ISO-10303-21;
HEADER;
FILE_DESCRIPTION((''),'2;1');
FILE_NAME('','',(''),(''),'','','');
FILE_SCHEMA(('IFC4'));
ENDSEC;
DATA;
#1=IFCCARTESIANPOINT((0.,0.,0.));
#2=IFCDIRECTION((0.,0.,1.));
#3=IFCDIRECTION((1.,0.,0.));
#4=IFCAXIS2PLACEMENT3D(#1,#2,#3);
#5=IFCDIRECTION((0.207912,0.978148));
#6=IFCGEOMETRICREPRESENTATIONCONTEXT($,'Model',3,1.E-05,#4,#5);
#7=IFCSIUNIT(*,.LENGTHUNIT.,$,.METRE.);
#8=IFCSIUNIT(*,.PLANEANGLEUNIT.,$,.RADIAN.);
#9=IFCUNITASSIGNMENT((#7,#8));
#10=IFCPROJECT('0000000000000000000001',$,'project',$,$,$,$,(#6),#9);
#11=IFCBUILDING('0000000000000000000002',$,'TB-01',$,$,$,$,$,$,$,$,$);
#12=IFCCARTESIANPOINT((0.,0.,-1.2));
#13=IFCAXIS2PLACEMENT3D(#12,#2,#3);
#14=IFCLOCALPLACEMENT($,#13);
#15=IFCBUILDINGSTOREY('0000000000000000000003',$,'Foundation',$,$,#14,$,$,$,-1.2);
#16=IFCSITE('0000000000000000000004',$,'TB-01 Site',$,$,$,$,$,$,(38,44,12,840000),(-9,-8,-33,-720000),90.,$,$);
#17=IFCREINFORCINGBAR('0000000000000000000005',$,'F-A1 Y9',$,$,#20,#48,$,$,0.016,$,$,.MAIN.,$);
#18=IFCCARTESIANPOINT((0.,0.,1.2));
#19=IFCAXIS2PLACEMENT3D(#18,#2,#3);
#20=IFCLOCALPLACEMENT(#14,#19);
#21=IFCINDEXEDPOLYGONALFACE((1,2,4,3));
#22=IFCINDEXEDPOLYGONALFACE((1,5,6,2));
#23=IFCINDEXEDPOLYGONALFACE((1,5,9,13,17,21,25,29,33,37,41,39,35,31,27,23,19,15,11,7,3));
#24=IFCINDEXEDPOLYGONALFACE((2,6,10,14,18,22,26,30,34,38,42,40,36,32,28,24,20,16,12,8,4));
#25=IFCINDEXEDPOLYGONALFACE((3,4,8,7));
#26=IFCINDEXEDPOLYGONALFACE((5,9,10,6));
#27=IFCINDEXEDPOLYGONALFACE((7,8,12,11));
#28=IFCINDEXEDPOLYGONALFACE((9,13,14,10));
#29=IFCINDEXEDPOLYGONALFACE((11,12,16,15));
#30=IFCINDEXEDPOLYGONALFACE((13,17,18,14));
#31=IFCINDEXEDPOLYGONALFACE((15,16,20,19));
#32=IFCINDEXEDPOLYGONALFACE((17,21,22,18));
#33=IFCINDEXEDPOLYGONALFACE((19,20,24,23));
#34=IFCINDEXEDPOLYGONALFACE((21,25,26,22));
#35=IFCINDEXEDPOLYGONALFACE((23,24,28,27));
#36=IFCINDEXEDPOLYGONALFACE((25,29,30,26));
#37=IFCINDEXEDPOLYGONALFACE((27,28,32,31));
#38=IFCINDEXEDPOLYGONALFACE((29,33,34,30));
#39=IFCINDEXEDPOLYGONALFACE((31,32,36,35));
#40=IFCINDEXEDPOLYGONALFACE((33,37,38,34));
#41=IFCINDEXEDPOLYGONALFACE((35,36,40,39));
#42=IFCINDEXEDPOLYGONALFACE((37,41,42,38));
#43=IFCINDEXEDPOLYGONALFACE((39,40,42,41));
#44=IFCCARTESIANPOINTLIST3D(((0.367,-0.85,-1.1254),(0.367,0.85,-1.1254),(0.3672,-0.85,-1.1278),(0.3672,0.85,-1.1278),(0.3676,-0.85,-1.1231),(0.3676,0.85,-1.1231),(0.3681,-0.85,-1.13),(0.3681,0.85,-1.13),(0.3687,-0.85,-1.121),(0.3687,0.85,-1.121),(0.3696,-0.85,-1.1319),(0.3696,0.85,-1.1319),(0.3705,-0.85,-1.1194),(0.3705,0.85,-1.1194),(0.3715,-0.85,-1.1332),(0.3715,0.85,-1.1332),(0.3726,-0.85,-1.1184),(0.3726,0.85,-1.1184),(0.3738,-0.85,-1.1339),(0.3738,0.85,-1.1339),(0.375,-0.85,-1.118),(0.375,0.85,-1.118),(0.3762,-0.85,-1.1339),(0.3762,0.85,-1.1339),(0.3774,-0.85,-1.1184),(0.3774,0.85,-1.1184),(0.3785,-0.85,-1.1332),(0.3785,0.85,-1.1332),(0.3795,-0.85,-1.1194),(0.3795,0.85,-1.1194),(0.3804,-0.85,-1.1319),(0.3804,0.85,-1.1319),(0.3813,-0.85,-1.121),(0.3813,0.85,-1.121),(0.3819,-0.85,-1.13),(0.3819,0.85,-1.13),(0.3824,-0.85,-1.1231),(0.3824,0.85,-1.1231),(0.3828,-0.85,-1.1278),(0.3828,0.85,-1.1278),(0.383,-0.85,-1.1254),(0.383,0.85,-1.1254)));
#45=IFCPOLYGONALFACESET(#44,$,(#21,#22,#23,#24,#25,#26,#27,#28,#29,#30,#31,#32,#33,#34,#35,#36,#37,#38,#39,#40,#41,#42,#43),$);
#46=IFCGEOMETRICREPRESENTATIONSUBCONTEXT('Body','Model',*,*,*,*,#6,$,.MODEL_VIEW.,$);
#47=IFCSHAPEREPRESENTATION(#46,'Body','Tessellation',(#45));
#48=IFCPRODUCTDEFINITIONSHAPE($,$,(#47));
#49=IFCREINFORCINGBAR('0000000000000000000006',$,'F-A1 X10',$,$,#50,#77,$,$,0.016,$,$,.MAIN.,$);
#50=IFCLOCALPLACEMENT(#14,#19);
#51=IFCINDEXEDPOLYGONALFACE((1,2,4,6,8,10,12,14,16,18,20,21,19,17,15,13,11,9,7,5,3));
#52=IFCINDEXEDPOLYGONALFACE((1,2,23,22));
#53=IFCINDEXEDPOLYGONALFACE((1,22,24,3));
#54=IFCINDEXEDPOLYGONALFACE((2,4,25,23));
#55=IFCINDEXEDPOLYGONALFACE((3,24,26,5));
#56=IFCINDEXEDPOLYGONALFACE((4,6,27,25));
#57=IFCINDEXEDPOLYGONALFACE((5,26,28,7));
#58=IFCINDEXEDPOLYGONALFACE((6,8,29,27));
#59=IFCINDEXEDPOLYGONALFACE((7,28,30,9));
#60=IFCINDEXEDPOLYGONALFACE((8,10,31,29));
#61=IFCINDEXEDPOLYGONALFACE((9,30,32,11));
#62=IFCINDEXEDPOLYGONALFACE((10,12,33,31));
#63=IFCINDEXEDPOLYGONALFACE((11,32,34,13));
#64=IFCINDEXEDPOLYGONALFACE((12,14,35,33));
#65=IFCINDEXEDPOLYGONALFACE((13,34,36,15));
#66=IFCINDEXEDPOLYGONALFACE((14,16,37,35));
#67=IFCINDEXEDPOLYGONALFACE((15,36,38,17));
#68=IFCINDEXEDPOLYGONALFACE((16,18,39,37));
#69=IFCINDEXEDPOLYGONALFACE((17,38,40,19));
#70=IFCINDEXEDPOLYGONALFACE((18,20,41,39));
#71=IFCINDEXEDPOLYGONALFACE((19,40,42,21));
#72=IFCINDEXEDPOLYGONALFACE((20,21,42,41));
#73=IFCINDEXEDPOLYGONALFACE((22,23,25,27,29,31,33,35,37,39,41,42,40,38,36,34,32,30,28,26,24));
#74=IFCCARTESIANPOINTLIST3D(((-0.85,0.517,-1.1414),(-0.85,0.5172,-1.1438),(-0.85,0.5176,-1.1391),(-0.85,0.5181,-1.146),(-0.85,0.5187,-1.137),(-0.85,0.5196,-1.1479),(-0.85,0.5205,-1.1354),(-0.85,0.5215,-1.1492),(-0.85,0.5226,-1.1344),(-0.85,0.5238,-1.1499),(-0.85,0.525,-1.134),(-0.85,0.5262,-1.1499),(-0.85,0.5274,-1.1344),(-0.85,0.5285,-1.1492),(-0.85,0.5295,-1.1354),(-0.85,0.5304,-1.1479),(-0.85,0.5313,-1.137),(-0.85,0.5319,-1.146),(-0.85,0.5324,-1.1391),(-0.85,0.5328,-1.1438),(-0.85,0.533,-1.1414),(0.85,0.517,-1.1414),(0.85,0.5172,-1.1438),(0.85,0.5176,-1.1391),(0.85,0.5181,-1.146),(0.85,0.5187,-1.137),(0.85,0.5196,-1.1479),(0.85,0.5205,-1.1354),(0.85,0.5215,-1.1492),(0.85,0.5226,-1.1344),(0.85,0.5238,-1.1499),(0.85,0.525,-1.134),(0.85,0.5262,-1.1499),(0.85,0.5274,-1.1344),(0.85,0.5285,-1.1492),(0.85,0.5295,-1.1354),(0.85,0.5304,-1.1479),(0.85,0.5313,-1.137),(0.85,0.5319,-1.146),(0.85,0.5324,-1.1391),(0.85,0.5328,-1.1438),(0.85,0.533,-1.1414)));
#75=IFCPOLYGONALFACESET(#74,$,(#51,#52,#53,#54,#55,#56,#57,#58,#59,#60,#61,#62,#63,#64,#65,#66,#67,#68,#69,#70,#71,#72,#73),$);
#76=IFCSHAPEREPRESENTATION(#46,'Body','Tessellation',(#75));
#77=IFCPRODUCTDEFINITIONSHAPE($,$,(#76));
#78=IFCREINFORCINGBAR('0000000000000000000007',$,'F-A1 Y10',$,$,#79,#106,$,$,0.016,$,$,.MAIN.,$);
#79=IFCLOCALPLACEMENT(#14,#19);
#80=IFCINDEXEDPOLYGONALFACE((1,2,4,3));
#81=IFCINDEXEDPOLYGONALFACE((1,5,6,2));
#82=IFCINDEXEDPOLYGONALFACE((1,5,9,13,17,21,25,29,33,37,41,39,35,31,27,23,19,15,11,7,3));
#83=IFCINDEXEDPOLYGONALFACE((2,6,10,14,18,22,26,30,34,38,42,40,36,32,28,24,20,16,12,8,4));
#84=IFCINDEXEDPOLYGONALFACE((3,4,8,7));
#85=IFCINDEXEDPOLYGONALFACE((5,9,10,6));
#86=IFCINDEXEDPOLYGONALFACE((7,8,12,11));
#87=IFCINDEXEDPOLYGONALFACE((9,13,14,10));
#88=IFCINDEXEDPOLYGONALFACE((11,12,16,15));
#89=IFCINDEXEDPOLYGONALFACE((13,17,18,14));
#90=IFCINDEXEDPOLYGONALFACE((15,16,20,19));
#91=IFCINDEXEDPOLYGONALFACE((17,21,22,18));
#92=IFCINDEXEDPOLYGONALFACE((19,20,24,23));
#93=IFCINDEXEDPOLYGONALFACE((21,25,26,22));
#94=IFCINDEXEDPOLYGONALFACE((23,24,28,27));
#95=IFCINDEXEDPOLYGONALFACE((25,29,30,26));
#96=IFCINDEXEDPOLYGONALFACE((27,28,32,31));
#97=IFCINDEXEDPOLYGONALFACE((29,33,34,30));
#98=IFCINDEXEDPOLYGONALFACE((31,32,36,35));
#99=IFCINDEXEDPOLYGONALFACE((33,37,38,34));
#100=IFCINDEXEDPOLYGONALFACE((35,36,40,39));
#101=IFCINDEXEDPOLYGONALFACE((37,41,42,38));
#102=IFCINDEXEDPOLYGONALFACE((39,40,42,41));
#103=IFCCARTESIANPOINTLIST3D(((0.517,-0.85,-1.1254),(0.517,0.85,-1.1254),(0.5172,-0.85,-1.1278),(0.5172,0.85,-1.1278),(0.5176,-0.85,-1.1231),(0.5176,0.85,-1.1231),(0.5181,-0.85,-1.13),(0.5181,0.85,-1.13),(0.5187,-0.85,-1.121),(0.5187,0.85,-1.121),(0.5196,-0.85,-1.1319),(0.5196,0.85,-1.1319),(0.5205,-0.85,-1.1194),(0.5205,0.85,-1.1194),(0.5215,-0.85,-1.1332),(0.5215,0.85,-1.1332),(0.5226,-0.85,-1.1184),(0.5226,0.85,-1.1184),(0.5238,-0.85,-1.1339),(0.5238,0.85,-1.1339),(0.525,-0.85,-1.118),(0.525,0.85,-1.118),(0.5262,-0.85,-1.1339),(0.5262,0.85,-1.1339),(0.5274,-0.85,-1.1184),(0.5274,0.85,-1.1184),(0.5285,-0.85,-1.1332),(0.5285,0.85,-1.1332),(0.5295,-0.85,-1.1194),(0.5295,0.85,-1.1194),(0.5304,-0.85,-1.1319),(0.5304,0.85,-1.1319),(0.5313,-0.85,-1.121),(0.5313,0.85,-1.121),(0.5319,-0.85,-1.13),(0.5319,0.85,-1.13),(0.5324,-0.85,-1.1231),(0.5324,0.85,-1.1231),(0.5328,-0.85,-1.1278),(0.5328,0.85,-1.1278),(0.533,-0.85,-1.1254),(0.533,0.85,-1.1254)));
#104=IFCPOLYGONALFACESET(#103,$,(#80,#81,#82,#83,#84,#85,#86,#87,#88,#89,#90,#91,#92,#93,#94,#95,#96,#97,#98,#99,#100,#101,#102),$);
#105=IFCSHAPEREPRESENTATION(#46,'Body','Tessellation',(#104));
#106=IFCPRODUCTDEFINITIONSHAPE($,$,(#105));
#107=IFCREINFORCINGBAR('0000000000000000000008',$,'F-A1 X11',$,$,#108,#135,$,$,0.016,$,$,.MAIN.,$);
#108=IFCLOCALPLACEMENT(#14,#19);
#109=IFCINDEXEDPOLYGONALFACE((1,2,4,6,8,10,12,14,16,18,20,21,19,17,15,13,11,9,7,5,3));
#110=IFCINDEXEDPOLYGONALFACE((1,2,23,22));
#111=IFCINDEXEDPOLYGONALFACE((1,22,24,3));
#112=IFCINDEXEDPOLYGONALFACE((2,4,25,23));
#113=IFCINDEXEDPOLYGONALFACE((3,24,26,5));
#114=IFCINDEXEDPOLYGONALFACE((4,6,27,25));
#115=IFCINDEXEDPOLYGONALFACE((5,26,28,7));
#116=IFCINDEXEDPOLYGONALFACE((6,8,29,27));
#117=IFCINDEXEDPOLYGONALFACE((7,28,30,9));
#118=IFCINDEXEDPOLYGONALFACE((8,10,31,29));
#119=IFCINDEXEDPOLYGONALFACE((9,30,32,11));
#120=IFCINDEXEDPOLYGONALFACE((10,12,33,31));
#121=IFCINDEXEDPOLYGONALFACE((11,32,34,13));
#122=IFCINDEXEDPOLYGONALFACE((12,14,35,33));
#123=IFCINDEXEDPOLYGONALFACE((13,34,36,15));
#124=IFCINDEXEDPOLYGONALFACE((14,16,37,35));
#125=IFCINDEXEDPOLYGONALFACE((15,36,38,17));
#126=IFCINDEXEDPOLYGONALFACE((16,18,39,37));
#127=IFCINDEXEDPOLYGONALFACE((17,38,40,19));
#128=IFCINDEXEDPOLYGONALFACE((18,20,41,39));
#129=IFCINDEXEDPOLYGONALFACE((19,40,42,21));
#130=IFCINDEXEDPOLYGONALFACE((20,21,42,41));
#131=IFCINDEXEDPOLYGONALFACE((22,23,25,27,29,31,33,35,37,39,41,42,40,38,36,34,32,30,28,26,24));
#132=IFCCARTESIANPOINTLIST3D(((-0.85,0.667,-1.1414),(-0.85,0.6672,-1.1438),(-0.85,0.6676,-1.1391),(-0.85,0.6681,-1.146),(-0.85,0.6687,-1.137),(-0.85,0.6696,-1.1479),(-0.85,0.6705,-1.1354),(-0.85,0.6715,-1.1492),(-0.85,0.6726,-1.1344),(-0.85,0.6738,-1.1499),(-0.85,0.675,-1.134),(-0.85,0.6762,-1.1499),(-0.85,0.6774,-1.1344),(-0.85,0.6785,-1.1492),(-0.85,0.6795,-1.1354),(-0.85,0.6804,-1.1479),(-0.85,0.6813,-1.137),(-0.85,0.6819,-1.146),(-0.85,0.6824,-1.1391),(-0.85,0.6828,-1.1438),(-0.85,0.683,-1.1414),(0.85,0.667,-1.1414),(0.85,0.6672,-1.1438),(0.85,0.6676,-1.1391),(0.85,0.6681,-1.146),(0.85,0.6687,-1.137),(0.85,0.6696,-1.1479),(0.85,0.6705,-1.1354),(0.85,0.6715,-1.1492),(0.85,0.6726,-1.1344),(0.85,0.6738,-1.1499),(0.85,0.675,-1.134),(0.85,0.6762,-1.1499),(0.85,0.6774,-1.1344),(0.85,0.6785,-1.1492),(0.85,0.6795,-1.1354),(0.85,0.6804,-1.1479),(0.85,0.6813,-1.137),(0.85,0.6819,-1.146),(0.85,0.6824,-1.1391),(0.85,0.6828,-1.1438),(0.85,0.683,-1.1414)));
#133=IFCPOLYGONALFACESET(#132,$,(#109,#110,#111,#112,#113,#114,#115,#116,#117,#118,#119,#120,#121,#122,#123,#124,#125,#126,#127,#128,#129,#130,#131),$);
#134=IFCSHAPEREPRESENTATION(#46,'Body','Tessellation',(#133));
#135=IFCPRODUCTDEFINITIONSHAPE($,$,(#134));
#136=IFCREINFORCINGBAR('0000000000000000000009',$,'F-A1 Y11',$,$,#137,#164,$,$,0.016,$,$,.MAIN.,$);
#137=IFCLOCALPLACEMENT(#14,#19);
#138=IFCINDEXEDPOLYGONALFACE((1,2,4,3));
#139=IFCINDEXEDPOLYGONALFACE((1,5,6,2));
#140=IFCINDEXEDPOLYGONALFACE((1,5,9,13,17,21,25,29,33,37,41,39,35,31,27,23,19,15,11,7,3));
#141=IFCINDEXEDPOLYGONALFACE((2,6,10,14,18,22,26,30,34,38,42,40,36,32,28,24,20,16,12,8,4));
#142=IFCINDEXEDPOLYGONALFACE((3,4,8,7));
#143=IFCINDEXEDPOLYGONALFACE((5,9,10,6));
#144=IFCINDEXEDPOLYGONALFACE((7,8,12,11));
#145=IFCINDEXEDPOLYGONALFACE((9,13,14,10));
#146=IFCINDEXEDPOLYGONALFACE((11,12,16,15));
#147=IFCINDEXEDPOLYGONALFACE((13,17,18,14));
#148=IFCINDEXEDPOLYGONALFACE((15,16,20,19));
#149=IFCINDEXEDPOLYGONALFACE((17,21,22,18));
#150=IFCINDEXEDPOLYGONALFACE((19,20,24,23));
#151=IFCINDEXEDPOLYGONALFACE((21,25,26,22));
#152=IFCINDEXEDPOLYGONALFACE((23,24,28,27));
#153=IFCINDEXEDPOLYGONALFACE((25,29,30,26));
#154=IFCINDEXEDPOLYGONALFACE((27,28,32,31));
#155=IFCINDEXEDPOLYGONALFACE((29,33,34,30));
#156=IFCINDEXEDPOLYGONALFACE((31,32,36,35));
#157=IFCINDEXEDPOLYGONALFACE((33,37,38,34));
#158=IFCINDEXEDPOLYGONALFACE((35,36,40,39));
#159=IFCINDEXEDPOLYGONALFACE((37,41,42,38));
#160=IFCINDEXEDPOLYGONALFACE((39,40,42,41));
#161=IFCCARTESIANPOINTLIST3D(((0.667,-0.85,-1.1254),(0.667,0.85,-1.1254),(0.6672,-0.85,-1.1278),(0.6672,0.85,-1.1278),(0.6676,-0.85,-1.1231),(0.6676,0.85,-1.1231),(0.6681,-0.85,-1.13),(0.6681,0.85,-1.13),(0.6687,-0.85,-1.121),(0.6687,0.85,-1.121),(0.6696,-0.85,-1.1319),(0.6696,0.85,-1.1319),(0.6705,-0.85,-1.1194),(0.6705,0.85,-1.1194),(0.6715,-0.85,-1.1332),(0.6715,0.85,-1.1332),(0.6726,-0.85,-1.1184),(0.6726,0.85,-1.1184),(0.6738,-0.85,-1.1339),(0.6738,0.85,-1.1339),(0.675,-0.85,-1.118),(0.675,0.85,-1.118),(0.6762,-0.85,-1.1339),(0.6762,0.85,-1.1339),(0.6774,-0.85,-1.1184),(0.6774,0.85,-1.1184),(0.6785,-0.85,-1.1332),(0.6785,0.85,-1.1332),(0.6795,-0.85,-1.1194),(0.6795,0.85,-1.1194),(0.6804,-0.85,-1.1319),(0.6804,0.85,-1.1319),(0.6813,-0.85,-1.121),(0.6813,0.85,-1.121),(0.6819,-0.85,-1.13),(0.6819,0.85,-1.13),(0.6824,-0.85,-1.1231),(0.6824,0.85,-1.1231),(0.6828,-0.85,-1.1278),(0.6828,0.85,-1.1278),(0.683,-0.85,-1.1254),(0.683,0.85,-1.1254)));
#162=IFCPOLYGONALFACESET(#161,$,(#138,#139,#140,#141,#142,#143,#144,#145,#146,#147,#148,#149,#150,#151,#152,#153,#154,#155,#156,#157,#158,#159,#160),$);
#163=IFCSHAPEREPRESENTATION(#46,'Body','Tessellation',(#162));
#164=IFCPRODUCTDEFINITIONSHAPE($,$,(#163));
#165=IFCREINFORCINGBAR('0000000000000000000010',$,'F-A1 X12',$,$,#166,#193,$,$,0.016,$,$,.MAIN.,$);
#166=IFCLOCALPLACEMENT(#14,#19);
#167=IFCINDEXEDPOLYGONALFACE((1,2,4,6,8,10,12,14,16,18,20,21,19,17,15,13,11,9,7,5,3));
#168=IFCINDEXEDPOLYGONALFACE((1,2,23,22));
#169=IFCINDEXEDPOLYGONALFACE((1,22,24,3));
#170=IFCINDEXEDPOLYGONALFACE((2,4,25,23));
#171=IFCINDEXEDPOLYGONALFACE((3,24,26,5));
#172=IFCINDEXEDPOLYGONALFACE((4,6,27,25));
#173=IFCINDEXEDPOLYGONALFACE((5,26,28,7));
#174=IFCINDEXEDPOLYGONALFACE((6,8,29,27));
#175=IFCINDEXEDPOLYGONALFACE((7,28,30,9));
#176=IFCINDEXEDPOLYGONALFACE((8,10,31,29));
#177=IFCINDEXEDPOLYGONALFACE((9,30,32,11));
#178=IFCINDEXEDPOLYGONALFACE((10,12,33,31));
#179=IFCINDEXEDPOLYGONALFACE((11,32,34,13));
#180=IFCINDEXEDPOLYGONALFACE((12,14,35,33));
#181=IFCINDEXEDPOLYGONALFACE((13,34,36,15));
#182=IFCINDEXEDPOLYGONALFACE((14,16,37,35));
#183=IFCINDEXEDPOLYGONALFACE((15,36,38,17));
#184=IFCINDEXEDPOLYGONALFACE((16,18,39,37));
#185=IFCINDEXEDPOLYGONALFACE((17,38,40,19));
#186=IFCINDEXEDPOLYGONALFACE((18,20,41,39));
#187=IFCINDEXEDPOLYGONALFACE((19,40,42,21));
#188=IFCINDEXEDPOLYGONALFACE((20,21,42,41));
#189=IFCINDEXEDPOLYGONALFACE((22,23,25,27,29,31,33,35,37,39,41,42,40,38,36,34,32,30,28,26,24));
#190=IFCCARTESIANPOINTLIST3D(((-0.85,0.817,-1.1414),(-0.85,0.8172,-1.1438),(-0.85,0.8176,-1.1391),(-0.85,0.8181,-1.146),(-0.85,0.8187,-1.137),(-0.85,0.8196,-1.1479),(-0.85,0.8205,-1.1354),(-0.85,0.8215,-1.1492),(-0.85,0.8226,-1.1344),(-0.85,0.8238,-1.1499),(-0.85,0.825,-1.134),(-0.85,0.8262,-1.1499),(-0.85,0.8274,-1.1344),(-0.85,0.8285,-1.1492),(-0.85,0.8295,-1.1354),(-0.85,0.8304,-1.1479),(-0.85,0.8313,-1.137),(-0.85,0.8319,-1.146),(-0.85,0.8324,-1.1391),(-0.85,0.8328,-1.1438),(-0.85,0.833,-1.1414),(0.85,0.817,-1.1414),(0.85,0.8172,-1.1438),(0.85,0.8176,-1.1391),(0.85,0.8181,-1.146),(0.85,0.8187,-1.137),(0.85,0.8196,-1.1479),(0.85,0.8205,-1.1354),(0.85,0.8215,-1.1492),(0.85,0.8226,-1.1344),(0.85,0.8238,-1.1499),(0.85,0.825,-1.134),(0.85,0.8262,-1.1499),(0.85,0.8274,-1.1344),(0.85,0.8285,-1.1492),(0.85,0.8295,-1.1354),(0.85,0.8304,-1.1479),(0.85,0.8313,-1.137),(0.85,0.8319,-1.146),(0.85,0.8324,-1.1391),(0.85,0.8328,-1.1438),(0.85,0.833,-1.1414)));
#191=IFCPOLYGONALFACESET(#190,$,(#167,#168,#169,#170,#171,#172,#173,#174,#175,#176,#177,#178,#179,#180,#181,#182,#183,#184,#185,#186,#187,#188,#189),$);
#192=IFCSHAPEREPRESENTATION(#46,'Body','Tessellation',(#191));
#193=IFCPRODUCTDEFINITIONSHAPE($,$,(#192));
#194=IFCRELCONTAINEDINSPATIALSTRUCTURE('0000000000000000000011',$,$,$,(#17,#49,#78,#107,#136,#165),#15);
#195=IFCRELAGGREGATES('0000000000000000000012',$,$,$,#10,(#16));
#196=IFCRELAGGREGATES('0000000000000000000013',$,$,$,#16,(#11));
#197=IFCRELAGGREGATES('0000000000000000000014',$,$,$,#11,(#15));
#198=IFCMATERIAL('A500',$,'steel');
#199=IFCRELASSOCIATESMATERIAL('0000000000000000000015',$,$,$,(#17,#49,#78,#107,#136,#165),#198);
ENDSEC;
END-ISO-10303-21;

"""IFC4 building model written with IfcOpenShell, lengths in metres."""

from ifc_helpers import new_model, entity, si_unit, direction, frame, origin_with_axes, place, context, subcontext, project, spatial, material, element, save


model = new_model("IFC4")

# Units and contexts
model_context = context("Model", 3, precision=1e-05, world=origin_with_axes(), true_north=direction((0.207912, 0.978148)))
body_context = subcontext(model_context, "Body", "Model", "MODEL_VIEW")
ifc_project = project(units=[si_unit("LENGTHUNIT", "METRE"), si_unit("PLANEANGLEUNIT", "RADIAN")], contexts=[model_context])

# Site, building, storey
site = spatial("IfcSite", under=ifc_project, Name="TB-01 Site", RefLatitude=(38, 44, 12, 840000), RefLongitude=(-9, -8, -33, -720000), RefElevation=90.0)
building = spatial("IfcBuilding", under=site, Name="TB-01")
storey_placement = place(None, frame((0.0, 0.0, -1.2), z_axis=(0.0, 0.0, 1.0), x_axis=(1.0, 0.0, 0.0)))
storey = spatial("IfcBuildingStorey", under=building, at=storey_placement, Name="Foundation", Elevation=-1.2)

# Reinforcing bars
ifc_material_1 = material(Name="A500", Category="steel")
reinforcing_bar_1_placement = place(storey_placement, frame((0.0, 0.0, 1.2), z_axis=(0.0, 0.0, 1.0), x_axis=(1.0, 0.0, 0.0)))
element("IfcReinforcingBar", 1, at=reinforcing_bar_1_placement, inside=storey, material=ifc_material_1, Name="F-A1 Y9", NominalDiameter=0.016, PredefinedType="MAIN", context=body_context, shape_type="AdvancedSweptSolid", body=[
    entity("IfcSweptDiskSolid", entity("IfcPolyline", [entity("IfcCartesianPoint", [0.375, -0.85, -1.126]), entity("IfcCartesianPoint", [0.375, 0.85, -1.126])]), 0.008),
])
reinforcing_bar_2_placement = place(storey_placement, frame((0.0, 0.0, 1.2), z_axis=(0.0, 0.0, 1.0), x_axis=(1.0, 0.0, 0.0)))
element("IfcReinforcingBar", 2, at=reinforcing_bar_2_placement, inside=storey, material=ifc_material_1, Name="F-A1 X10", NominalDiameter=0.016, PredefinedType="MAIN", context=body_context, shape_type="AdvancedSweptSolid", body=[
    entity("IfcSweptDiskSolid", entity("IfcPolyline", [entity("IfcCartesianPoint", [-0.85, 0.525, -1.142]), entity("IfcCartesianPoint", [0.85, 0.525, -1.142])]), 0.008),
])
reinforcing_bar_3_placement = place(storey_placement, frame((0.0, 0.0, 1.2), z_axis=(0.0, 0.0, 1.0), x_axis=(1.0, 0.0, 0.0)))
element("IfcReinforcingBar", 3, at=reinforcing_bar_3_placement, inside=storey, material=ifc_material_1, Name="F-A1 Y10", NominalDiameter=0.016, PredefinedType="MAIN", context=body_context, shape_type="AdvancedSweptSolid", body=[
    entity("IfcSweptDiskSolid", entity("IfcPolyline", [entity("IfcCartesianPoint", [0.525, -0.85, -1.126]), entity("IfcCartesianPoint", [0.525, 0.85, -1.126])]), 0.008),
])
reinforcing_bar_4_placement = place(storey_placement, frame((0.0, 0.0, 1.2), z_axis=(0.0, 0.0, 1.0), x_axis=(1.0, 0.0, 0.0)))
element("IfcReinforcingBar", 4, at=reinforcing_bar_4_placement, inside=storey, material=ifc_material_1, Name="F-A1 X11", NominalDiameter=0.016, PredefinedType="MAIN", context=body_context, shape_type="AdvancedSweptSolid", body=[
    entity("IfcSweptDiskSolid", entity("IfcPolyline", [entity("IfcCartesianPoint", [-0.85, 0.675, -1.142]), entity("IfcCartesianPoint", [0.85, 0.675, -1.142])]), 0.008),
])
reinforcing_bar_5_placement = place(storey_placement, frame((0.0, 0.0, 1.2), z_axis=(0.0, 0.0, 1.0), x_axis=(1.0, 0.0, 0.0)))
element("IfcReinforcingBar", 5, at=reinforcing_bar_5_placement, inside=storey, material=ifc_material_1, Name="F-A1 Y11", NominalDiameter=0.016, PredefinedType="MAIN", context=body_context, shape_type="AdvancedSweptSolid", body=[
    entity("IfcSweptDiskSolid", entity("IfcPolyline", [entity("IfcCartesianPoint", [0.675, -0.85, -1.126]), entity("IfcCartesianPoint", [0.675, 0.85, -1.126])]), 0.008),
])
reinforcing_bar_6_placement = place(storey_placement, frame((0.0, 0.0, 1.2), z_axis=(0.0, 0.0, 1.0), x_axis=(1.0, 0.0, 0.0)))
element("IfcReinforcingBar", 6, at=reinforcing_bar_6_placement, inside=storey, material=ifc_material_1, Name="F-A1 X12", NominalDiameter=0.016, PredefinedType="MAIN", context=body_context, shape_type="AdvancedSweptSolid", body=[
    entity("IfcSweptDiskSolid", entity("IfcPolyline", [entity("IfcCartesianPoint", [-0.85, 0.825, -1.142]), entity("IfcCartesianPoint", [0.85, 0.825, -1.142])]), 0.008),
])

save(model, "model.ifc")
